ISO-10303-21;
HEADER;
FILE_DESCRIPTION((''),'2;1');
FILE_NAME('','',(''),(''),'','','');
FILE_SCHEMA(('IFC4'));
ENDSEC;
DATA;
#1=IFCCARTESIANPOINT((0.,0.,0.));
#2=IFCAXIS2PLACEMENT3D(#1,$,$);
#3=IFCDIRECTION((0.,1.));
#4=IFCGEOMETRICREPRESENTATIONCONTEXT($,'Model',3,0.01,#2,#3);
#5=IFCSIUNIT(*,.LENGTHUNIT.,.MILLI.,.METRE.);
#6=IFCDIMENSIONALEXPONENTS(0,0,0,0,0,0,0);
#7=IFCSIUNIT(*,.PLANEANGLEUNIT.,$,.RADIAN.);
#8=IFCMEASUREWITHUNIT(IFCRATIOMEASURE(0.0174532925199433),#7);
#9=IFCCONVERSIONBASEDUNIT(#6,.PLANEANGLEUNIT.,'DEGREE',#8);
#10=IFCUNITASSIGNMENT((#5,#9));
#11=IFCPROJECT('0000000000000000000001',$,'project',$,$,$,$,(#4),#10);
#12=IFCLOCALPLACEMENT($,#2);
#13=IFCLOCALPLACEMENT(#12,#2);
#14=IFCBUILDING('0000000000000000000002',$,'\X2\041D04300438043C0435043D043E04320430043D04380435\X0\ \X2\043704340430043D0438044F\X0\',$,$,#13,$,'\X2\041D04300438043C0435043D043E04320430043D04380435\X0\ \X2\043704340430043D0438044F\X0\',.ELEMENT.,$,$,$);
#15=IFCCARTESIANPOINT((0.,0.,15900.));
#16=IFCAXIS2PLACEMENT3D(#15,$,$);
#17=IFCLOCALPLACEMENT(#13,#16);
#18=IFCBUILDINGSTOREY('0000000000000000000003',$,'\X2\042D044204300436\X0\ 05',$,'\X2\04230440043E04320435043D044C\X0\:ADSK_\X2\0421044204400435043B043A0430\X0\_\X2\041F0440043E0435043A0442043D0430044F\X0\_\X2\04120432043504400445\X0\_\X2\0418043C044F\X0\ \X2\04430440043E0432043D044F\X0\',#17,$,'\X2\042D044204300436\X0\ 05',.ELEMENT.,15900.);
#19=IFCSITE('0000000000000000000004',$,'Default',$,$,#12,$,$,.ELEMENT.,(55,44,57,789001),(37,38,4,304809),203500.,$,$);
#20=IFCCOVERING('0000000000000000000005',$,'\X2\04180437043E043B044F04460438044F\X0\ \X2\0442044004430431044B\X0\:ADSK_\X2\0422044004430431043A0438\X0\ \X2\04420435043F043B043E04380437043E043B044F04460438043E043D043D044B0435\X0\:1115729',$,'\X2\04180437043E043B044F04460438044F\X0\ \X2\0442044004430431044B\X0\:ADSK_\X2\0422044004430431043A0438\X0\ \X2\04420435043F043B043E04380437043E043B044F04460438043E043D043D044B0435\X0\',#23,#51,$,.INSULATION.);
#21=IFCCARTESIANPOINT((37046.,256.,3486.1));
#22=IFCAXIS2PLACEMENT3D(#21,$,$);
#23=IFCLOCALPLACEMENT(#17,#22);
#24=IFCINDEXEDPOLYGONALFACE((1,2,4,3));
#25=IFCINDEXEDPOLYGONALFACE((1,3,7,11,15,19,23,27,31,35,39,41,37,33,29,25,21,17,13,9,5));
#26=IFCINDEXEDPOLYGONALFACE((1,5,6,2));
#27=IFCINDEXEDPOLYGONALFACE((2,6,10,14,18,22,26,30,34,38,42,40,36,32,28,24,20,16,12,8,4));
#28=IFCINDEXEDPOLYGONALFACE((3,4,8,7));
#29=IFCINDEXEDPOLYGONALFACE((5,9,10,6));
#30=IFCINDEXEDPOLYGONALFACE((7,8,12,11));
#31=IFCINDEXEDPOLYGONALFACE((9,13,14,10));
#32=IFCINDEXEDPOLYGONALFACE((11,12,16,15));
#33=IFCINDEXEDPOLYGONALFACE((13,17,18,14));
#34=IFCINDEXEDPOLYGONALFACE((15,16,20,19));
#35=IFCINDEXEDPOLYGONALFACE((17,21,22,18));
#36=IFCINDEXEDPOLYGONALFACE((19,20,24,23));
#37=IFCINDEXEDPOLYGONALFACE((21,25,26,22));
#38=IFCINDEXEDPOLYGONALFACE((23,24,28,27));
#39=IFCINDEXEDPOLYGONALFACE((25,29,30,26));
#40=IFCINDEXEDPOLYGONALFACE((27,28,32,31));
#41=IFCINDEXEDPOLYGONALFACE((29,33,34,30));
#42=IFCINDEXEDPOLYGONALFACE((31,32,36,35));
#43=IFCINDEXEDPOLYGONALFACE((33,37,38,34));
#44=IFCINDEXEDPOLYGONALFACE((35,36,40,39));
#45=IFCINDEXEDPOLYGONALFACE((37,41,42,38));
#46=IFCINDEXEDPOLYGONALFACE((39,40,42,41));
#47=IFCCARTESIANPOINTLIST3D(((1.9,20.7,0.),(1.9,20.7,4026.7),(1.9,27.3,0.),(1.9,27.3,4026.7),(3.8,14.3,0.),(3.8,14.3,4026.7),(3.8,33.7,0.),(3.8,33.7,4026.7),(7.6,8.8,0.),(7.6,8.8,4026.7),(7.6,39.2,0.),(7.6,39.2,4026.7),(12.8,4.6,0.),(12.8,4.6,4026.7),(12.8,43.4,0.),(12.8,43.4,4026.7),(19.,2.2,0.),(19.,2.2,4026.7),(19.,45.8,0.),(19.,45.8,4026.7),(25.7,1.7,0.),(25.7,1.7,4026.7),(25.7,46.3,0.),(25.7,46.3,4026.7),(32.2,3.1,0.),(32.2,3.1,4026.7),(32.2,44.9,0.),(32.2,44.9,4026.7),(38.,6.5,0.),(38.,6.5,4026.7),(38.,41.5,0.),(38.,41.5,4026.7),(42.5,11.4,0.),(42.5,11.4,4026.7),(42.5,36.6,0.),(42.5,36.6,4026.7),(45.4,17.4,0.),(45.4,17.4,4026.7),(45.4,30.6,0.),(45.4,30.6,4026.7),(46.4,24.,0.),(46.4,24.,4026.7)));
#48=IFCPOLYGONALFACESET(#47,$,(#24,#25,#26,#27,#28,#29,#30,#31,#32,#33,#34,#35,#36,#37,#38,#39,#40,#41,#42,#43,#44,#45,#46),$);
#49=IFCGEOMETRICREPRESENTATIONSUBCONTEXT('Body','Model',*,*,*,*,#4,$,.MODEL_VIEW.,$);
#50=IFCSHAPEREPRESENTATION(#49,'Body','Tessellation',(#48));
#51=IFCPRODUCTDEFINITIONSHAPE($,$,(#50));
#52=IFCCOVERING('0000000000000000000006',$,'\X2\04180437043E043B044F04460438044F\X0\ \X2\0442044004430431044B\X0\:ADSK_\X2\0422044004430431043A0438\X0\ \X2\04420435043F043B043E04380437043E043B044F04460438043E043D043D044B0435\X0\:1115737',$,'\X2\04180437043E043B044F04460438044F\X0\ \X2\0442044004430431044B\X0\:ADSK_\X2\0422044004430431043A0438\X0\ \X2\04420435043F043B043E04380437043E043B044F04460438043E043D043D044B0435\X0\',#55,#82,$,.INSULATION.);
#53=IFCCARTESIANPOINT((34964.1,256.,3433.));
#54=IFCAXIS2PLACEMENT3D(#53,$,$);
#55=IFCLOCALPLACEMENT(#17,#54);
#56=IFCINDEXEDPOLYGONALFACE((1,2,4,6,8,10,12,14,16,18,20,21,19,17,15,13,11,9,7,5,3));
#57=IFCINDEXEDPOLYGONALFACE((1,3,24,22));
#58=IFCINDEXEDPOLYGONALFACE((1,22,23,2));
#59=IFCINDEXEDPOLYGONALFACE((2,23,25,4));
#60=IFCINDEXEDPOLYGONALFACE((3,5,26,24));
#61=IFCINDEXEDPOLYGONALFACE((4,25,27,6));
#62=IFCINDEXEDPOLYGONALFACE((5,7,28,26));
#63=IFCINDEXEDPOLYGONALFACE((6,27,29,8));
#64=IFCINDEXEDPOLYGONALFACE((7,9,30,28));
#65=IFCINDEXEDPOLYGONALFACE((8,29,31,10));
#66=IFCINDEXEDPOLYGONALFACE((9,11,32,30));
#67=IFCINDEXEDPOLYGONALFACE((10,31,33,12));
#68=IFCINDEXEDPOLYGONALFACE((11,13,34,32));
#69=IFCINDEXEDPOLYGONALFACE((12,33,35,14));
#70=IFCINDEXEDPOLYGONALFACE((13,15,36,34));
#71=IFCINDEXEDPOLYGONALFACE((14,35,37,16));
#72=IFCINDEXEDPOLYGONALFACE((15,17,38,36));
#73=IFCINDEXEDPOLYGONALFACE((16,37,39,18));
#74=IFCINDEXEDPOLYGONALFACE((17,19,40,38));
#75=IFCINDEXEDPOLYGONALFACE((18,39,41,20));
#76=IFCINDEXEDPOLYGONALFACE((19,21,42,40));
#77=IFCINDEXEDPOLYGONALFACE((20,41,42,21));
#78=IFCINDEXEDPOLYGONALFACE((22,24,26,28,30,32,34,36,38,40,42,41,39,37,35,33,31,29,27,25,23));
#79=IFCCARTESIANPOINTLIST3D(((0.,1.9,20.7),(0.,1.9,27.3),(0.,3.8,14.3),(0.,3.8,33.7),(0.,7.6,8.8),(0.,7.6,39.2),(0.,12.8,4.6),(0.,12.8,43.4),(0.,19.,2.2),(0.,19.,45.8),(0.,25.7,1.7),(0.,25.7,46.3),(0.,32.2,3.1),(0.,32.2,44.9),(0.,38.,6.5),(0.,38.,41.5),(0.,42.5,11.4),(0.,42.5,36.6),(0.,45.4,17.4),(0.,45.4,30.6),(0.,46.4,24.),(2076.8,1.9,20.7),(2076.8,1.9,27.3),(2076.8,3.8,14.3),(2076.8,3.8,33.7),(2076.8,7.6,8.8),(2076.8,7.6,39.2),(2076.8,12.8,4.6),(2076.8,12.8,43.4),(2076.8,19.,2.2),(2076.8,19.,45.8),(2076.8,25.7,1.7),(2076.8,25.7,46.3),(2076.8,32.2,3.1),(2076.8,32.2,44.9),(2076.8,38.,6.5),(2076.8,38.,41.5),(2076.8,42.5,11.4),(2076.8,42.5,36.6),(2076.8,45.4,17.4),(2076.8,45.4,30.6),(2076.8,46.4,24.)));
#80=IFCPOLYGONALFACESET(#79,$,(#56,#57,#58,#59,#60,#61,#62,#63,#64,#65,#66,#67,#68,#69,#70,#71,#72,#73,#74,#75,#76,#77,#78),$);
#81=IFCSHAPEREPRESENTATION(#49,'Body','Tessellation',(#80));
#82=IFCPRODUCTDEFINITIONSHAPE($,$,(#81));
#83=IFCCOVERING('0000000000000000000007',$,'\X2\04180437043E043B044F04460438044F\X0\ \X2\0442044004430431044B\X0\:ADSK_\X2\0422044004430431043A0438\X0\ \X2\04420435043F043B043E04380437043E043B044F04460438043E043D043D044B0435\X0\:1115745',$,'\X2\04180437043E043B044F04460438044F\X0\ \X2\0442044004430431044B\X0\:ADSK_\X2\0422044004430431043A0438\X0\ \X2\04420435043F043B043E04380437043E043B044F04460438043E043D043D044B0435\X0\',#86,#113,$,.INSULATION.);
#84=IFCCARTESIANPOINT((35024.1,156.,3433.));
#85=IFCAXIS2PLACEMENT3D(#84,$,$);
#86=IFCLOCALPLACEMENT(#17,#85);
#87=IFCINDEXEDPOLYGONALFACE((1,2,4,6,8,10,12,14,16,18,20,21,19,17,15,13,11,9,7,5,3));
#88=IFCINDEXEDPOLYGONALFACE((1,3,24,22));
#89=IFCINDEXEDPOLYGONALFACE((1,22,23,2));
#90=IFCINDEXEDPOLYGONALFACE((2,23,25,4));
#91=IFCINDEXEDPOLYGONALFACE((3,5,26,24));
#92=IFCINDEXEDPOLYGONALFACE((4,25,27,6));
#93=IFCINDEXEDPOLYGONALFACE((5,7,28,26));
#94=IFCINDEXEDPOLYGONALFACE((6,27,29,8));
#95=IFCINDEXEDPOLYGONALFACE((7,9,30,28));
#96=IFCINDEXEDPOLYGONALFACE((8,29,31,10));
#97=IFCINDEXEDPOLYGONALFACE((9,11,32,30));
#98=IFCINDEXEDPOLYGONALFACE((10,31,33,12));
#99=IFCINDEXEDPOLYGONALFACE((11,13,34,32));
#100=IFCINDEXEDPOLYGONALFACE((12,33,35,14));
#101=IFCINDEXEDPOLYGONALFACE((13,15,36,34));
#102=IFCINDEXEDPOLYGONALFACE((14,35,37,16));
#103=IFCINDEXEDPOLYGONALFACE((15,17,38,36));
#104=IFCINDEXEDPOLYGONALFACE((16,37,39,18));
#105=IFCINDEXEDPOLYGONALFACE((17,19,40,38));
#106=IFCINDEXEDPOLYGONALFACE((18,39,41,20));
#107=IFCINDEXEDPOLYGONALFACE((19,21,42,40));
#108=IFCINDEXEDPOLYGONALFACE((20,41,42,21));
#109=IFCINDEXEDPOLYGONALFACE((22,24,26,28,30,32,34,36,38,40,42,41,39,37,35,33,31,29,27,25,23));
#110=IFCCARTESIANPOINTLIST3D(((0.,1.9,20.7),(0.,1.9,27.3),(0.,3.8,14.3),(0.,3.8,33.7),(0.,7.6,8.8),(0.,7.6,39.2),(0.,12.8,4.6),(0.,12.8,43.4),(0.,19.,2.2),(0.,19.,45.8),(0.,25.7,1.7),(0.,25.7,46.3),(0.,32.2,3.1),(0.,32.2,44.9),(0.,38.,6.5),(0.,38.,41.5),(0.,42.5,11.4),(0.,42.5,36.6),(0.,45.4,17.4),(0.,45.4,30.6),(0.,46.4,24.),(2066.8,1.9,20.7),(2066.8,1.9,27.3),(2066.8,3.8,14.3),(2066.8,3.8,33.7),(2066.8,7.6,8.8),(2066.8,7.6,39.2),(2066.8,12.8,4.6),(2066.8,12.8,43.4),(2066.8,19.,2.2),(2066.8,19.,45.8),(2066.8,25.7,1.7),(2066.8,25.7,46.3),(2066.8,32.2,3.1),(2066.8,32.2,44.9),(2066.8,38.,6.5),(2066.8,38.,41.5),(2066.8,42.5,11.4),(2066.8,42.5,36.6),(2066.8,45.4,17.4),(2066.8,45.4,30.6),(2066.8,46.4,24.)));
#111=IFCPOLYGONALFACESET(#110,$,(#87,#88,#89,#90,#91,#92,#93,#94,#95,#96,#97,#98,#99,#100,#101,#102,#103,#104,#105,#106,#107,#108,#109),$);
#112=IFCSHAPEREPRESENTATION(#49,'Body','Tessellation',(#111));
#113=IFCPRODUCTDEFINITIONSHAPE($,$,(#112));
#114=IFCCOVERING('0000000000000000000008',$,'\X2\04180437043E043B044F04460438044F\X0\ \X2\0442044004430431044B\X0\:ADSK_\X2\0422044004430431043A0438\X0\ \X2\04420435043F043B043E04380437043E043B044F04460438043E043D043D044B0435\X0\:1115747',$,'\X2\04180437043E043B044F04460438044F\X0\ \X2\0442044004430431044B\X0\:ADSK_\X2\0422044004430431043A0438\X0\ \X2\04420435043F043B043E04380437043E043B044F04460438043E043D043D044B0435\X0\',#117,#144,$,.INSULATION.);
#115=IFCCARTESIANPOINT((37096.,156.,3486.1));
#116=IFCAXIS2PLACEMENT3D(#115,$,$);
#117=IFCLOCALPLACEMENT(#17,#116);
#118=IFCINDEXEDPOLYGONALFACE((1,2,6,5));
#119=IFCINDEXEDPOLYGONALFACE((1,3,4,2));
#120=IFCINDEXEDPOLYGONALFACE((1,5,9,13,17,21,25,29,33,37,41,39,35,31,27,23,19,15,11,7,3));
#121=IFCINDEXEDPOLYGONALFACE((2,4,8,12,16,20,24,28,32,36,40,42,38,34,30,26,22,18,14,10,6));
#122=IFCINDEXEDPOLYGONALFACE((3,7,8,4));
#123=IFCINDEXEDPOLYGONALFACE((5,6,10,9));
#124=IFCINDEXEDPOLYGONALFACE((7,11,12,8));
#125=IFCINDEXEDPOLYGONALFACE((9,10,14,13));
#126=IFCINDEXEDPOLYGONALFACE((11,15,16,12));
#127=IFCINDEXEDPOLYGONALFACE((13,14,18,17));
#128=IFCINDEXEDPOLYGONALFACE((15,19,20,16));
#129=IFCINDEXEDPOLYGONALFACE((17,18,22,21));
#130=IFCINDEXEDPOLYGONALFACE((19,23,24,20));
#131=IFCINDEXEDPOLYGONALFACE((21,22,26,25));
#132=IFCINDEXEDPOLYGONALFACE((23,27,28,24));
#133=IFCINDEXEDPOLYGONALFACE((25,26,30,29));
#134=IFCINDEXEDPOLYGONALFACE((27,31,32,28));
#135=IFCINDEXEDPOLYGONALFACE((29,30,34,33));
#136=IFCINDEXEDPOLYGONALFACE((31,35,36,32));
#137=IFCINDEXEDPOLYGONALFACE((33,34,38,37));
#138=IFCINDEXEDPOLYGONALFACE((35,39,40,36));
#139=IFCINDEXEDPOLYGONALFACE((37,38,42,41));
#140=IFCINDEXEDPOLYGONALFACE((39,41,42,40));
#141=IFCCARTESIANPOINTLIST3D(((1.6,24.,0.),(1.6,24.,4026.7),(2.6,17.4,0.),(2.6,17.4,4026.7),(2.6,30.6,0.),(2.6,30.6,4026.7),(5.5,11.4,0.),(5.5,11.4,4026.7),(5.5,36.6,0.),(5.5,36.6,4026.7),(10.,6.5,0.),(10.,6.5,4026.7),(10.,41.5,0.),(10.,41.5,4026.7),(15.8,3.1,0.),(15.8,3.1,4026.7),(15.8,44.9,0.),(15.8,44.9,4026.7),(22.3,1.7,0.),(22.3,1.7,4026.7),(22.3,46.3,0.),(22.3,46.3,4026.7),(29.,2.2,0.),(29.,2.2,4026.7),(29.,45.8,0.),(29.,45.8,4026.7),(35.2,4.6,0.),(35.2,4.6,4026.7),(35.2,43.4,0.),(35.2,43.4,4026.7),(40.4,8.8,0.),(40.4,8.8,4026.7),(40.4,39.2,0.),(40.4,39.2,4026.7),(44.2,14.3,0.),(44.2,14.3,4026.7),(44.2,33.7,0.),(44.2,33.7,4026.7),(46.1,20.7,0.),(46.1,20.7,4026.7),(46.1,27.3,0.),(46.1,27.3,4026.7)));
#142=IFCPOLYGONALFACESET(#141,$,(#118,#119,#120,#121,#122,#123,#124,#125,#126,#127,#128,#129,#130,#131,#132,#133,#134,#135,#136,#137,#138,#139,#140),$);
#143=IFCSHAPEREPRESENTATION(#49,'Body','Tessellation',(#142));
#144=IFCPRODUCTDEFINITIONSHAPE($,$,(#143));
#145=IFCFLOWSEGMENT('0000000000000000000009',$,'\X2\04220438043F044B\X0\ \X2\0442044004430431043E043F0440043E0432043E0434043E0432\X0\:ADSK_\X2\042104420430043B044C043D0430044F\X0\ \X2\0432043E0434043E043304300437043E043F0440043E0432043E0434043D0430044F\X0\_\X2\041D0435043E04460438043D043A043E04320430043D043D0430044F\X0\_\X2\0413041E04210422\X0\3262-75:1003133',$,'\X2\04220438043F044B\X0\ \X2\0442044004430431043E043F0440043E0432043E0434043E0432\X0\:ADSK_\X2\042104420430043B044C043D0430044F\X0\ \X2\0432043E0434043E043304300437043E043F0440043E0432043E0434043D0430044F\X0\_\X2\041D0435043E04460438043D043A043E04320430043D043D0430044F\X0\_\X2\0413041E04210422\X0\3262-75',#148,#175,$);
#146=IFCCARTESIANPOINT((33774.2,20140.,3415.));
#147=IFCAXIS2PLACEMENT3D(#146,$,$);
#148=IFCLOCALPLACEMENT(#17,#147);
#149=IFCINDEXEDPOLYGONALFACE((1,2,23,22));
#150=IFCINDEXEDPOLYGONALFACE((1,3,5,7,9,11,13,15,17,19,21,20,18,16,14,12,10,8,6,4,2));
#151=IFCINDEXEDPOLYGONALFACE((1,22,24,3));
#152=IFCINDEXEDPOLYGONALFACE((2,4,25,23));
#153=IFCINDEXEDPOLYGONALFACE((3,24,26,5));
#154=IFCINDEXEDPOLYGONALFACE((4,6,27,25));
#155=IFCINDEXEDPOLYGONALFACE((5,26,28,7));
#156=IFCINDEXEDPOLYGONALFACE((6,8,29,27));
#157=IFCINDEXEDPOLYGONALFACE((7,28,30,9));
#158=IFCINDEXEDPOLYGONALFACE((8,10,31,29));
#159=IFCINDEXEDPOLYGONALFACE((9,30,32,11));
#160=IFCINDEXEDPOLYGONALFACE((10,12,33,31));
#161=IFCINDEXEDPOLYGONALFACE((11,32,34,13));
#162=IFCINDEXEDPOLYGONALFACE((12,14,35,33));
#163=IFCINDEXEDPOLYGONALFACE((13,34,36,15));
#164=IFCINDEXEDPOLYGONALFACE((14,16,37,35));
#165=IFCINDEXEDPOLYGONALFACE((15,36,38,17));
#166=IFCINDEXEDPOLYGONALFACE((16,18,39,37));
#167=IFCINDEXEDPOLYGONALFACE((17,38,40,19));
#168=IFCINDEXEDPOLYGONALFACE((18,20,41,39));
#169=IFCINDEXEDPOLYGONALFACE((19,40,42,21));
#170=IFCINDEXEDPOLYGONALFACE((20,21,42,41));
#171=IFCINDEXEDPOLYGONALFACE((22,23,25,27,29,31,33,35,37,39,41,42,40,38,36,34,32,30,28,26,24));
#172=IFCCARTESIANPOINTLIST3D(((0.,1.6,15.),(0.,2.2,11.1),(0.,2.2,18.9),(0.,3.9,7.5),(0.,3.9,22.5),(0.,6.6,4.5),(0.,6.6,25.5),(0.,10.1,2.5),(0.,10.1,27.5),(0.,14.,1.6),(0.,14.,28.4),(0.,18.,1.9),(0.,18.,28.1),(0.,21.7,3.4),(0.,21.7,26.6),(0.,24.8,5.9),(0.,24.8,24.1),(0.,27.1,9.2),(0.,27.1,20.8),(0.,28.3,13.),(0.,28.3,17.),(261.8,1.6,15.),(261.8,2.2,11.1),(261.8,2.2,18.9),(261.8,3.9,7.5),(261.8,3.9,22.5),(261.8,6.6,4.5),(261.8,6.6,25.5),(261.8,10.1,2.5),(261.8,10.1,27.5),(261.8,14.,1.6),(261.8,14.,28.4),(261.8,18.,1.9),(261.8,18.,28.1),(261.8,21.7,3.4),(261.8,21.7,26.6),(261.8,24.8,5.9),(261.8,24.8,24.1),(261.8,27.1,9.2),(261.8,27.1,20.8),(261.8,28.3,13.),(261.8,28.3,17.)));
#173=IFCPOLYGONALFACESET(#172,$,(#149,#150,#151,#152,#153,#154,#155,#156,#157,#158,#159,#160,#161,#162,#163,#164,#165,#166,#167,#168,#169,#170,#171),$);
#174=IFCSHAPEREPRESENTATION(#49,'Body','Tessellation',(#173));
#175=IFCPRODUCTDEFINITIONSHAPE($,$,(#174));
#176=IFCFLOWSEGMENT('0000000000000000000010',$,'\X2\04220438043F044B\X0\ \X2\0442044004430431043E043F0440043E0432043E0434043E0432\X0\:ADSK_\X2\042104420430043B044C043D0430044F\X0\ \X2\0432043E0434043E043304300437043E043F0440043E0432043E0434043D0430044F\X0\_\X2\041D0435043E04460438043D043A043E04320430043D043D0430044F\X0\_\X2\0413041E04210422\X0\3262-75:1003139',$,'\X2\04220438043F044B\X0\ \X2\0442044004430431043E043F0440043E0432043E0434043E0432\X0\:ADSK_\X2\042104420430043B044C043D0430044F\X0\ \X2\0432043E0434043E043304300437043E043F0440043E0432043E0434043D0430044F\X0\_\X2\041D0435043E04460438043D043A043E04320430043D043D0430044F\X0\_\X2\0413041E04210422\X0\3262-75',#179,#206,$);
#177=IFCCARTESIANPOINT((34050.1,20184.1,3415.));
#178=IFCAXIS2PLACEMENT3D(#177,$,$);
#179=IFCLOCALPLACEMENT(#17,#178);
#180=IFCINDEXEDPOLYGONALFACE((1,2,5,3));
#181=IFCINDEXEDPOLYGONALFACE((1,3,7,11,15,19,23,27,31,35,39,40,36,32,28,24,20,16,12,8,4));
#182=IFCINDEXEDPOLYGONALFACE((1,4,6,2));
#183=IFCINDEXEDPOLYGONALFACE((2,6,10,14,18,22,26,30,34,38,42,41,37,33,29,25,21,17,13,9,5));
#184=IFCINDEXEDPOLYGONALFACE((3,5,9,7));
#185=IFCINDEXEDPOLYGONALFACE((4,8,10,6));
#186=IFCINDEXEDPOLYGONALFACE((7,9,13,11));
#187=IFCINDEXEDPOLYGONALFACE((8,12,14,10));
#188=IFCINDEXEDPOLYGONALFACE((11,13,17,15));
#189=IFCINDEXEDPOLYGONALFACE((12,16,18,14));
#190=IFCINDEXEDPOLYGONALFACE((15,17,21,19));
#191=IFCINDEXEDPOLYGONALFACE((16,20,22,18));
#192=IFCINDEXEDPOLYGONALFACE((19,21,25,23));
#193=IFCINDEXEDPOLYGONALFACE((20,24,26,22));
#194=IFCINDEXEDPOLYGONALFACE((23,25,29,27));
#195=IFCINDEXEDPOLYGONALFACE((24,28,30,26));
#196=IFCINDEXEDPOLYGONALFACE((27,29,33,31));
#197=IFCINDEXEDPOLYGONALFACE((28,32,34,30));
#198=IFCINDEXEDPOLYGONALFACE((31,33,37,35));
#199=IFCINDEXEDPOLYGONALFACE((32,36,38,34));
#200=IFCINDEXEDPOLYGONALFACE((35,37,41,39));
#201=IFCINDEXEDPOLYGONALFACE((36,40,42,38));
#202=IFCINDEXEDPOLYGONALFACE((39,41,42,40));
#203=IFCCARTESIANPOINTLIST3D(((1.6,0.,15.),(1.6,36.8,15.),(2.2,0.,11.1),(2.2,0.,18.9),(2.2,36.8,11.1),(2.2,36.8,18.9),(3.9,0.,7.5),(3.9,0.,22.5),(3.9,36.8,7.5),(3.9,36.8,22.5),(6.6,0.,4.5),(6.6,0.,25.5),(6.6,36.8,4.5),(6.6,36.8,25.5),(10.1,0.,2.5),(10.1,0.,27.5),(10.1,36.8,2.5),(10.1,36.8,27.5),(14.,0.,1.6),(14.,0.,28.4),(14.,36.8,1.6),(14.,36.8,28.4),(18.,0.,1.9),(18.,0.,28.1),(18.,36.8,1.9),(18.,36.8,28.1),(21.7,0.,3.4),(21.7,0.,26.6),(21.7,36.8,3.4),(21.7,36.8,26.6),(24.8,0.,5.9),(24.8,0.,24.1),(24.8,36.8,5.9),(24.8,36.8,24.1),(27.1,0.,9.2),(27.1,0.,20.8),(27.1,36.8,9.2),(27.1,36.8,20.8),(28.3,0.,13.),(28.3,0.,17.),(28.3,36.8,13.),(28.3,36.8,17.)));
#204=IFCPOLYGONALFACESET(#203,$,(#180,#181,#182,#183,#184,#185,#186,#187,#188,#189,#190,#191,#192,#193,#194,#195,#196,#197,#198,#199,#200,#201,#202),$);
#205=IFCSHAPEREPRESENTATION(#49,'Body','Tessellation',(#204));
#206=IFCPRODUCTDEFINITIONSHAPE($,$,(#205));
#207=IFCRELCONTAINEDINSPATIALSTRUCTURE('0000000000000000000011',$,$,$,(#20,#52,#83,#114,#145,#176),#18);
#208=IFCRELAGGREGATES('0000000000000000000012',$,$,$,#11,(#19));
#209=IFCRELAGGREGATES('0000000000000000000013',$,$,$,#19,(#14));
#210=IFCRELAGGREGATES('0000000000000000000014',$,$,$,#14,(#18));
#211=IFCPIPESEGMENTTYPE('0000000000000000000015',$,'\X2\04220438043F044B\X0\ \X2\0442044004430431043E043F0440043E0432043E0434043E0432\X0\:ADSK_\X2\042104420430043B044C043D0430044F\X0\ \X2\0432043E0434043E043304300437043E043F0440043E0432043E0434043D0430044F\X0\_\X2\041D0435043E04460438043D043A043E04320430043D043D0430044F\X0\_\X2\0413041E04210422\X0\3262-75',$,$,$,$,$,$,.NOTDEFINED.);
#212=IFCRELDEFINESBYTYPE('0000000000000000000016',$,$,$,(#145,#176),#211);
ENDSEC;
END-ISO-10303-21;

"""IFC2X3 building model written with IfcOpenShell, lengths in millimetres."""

from ifc_helpers import new_model, entity, si_unit, converted_unit, direction, frame, origin, origin_2d_with_axis, place, context, subcontext, project, spatial, circle, extrude, type_object, element, save


model = new_model("IFC2X3")

# Units and contexts
model_context = context("Model", 3, precision=0.01, world=origin(), true_north=direction((0.0, 1.0)))
body_context = subcontext(model_context, "Body", "Model", "MODEL_VIEW")
ifc_project = project(units=[si_unit("LENGTHUNIT", "METRE", prefix="MILLI"), converted_unit("PLANEANGLEUNIT", "DEGREE", entity("IfcRatioMeasure", 0.0174532925199433), si_unit("PLANEANGLEUNIT", "RADIAN"), dimensions=[0, 0, 0, 0, 0, 0, 0])], contexts=[model_context])

# Site, building, storey
site_placement = place(None, origin())
site = spatial("IfcSite", under=ifc_project, at=site_placement, Name="Default", CompositionType="ELEMENT", RefLatitude=(55, 44, 57, 789001), RefLongitude=(37, 38, 4, 304809), RefElevation=203500.0)
building_placement = place(site_placement, origin())
building = spatial("IfcBuilding", under=site, at=building_placement, Name="Наименование здания", LongName="Наименование здания", CompositionType="ELEMENT")
storey_placement = place(building_placement, frame((0.0, 0.0, 15900.0)))
storey = spatial("IfcBuildingStorey", under=building, at=storey_placement, Name="Этаж 05", ObjectType="Уровень:ADSK_Стрелка_Проектная_Вверх_Имя уровня", LongName="Этаж 05", CompositionType="ELEMENT", Elevation=15900.0)

# Coverings
covering_1_placement = place(storey_placement, frame((37046.0, 256.0, 3486.1)))
element("IfcCovering", 1, at=covering_1_placement, inside=storey, Name="Изоляция трубы:ADSK_Трубки теплоизоляционные:1115729", ObjectType="Изоляция трубы:ADSK_Трубки теплоизоляционные", PredefinedType="INSULATION", context=body_context, shape_type="SweptSolid", body=[
    extrude(circle(Radius=22.4, at=origin_2d_with_axis()), frame((24.0, 24.0, 0.0)), (0.0, 0.0, 1.0), 4026.7),
])
covering_2_placement = place(storey_placement, frame((34964.1, 256.0, 3433.0)))
element("IfcCovering", 2, at=covering_2_placement, inside=storey, Name="Изоляция трубы:ADSK_Трубки теплоизоляционные:1115737", ObjectType="Изоляция трубы:ADSK_Трубки теплоизоляционные", PredefinedType="INSULATION", context=body_context, shape_type="SweptSolid", body=[
    extrude(circle(Radius=22.4, at=origin_2d_with_axis()), frame((0.0, 24.0, 24.0), z_axis=(1.0, 0.0, 0.0), x_axis=(0.0, 1.0, 0.0)), (0.0, 0.0, 1.0), 2076.8),
])
covering_3_placement = place(storey_placement, frame((35024.1, 156.0, 3433.0)))
element("IfcCovering", 3, at=covering_3_placement, inside=storey, Name="Изоляция трубы:ADSK_Трубки теплоизоляционные:1115745", ObjectType="Изоляция трубы:ADSK_Трубки теплоизоляционные", PredefinedType="INSULATION", context=body_context, shape_type="SweptSolid", body=[
    extrude(circle(Radius=22.4, at=origin_2d_with_axis()), frame((0.0, 24.0, 24.0), z_axis=(1.0, 0.0, 0.0), x_axis=(0.0, 1.0, 0.0)), (0.0, 0.0, 1.0), 2066.8),
])
covering_4_placement = place(storey_placement, frame((37096.0, 156.0, 3486.1)))
element("IfcCovering", 4, at=covering_4_placement, inside=storey, Name="Изоляция трубы:ADSK_Трубки теплоизоляционные:1115747", ObjectType="Изоляция трубы:ADSK_Трубки теплоизоляционные", PredefinedType="INSULATION", context=body_context, shape_type="SweptSolid", body=[
    extrude(circle(Radius=22.4, at=origin_2d_with_axis()), frame((24.0, 24.0, 0.0), z_axis=(0.0, 0.0, 1.0), x_axis=(-1.0, 0.0, 0.0)), (0.0, 0.0, 1.0), 4026.7),
])

# Flow segments
pipe_segment_type = type_object("IfcPipeSegmentType", Name="Типы трубопроводов:ADSK_Стальная водогазопроводная_Неоцинкованная_ГОСТ3262-75", PredefinedType="NOTDEFINED")
flow_segment_1_placement = place(storey_placement, frame((33774.2, 20140.0, 3415.0)))
element("IfcFlowSegment", 5, at=flow_segment_1_placement, inside=storey, type_object=pipe_segment_type, Name="Типы трубопроводов:ADSK_Стальная водогазопроводная_Неоцинкованная_ГОСТ3262-75:1003133", ObjectType="Типы трубопроводов:ADSK_Стальная водогазопроводная_Неоцинкованная_ГОСТ3262-75", context=body_context, shape_type="SweptSolid", body=[
    extrude(circle(Radius=13.4, at=origin_2d_with_axis()), frame((0.0, 15.0, 15.0), z_axis=(1.0, 0.0, 0.0), x_axis=(0.0, -1.0, 0.0)), (0.0, 0.0, 1.0), 261.8),
])
flow_segment_2_placement = place(storey_placement, frame((34050.1, 20184.1, 3415.0)))
element("IfcFlowSegment", 6, at=flow_segment_2_placement, inside=storey, type_object=pipe_segment_type, Name="Типы трубопроводов:ADSK_Стальная водогазопроводная_Неоцинкованная_ГОСТ3262-75:1003139", ObjectType="Типы трубопроводов:ADSK_Стальная водогазопроводная_Неоцинкованная_ГОСТ3262-75", context=body_context, shape_type="SweptSolid", body=[
    extrude(circle(Radius=13.4, at=origin_2d_with_axis()), frame((15.0, 0.0, 15.0), z_axis=(0.0, 1.0, 0.0), x_axis=(-1.0, 0.0, 0.0)), (0.0, 0.0, 1.0), 36.8),
])

save(model, "model.ifc")
